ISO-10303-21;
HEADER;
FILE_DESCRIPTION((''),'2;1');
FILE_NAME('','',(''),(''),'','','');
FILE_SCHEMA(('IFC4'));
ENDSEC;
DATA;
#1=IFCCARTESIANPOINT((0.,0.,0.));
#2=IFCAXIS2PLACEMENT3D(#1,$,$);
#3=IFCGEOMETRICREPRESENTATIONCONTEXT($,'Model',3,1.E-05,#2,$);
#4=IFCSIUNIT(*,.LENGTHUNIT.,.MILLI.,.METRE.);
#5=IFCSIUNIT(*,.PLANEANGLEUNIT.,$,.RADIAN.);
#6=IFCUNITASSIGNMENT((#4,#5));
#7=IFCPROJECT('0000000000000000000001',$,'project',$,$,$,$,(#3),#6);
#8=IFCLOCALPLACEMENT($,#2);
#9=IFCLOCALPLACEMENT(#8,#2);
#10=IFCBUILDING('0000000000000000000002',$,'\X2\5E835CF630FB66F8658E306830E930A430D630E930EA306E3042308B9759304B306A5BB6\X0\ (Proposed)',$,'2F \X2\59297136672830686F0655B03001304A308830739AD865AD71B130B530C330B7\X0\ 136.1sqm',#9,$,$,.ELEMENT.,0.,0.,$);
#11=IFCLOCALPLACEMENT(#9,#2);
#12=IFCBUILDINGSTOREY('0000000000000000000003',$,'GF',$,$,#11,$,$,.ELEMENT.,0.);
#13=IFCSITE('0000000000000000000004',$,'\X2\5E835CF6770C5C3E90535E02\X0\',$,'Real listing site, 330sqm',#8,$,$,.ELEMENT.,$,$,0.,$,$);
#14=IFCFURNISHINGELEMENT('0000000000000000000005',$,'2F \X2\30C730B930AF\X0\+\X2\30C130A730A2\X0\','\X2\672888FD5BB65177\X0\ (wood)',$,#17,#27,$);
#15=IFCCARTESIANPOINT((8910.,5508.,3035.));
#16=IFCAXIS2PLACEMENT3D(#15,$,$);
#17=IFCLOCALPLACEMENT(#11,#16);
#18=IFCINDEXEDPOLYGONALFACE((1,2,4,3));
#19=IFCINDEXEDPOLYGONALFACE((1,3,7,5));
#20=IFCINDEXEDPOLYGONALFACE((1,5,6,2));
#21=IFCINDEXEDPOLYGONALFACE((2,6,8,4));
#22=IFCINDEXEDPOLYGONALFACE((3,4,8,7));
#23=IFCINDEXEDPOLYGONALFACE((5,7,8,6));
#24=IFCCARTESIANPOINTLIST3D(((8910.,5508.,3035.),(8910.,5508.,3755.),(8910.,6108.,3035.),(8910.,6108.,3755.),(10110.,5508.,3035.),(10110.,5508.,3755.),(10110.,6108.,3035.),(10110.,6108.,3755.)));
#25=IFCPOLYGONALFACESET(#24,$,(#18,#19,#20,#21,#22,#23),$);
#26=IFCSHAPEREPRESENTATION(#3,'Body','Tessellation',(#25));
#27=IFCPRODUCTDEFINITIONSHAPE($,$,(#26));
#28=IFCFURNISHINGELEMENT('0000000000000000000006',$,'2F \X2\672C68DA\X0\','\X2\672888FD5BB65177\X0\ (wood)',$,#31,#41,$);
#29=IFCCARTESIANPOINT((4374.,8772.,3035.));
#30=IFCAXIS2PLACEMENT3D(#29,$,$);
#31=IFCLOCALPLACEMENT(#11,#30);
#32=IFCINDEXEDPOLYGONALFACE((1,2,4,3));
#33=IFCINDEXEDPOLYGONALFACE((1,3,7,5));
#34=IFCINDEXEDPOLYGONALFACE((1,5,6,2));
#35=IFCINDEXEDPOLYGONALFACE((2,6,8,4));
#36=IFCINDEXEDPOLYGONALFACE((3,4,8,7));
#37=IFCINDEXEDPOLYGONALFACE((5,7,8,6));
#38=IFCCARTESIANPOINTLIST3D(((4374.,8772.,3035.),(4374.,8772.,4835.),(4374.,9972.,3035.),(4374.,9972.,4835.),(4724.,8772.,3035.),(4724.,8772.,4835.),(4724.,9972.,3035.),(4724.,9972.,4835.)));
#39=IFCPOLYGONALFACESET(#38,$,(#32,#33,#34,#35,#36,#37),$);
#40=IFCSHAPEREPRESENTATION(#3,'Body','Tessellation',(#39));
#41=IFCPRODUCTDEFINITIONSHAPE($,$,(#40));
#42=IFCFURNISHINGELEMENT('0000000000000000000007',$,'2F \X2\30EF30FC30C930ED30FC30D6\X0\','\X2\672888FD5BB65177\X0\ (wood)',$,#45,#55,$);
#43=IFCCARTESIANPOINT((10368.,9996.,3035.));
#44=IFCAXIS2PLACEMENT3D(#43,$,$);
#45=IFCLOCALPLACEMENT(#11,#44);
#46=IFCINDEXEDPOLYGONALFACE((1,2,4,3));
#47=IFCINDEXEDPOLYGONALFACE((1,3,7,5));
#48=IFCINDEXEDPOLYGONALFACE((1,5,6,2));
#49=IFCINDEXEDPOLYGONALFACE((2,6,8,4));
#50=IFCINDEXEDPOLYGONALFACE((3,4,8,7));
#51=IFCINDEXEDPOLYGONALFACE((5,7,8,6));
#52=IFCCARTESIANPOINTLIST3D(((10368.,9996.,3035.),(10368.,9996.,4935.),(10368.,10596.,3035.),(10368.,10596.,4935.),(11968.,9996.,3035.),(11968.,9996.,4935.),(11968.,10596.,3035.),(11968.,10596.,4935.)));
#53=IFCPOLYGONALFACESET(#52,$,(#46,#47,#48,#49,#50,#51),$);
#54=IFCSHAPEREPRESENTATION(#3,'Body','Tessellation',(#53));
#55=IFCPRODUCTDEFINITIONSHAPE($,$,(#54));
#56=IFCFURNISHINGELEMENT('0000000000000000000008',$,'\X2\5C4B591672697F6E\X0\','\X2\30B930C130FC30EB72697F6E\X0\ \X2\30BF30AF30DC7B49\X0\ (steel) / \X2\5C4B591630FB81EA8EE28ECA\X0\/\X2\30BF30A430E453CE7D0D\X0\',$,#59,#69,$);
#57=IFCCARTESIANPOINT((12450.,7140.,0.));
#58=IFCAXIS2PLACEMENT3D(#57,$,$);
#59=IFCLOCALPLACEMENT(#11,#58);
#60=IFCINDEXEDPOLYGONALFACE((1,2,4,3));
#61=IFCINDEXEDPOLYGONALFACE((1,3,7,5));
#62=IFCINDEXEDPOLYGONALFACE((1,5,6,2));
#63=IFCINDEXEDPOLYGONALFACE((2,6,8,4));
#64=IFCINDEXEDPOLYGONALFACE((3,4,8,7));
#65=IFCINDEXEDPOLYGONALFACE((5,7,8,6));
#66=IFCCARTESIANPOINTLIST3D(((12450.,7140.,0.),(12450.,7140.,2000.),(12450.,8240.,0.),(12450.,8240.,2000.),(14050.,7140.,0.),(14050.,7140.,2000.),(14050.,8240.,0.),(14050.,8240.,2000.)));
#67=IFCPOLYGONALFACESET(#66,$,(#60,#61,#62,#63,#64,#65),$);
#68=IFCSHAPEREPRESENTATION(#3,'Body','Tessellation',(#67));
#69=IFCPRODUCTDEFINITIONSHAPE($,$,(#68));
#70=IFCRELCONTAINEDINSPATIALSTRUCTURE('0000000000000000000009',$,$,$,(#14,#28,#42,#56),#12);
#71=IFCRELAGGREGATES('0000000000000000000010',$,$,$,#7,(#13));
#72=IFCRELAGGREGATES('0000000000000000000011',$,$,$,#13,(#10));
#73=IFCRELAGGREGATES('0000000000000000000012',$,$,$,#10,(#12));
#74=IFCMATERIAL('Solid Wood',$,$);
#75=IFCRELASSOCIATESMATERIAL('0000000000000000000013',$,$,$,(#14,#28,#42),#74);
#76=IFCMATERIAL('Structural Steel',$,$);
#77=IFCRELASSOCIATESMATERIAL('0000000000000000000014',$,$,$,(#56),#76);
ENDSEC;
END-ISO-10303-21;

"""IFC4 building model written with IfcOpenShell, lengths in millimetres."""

from ifc_helpers import new_model, si_unit, frame, frame_2d, origin, place, context, project, spatial, rectangle, extrude, material, element, save


model = new_model("IFC4")

# Units and contexts
model_context = context("Model", 3, precision=1e-05, world=origin())
ifc_project = project(units=[si_unit("LENGTHUNIT", "METRE", prefix="MILLI"), si_unit("PLANEANGLEUNIT", "RADIAN")], contexts=[model_context])

# Site, building, storey
site_placement = place(None, origin())
site = spatial("IfcSite", under=ifc_project, at=site_placement, Name="広島県尾道市", ObjectType="Real listing site, 330sqm", CompositionType="ELEMENT", RefElevation=0.0)
building_placement = place(site_placement, origin())
building = spatial("IfcBuilding", under=site, at=building_placement, Name="広島・書斎とライブラリのある静かな家 (Proposed)", ObjectType="2F 天然木と漆喰、および高断熱サッシ 136.1sqm", CompositionType="ELEMENT", ElevationOfRefHeight=0.0, ElevationOfTerrain=0.0)
storey_placement = place(building_placement, origin())
storey = spatial("IfcBuildingStorey", under=building, at=storey_placement, Name="GF", CompositionType="ELEMENT", Elevation=0.0)

# Shared definitions
ifc_material_1 = material(Name="Solid Wood")

# Shared definitions
ifc_material_2 = material(Name="Structural Steel")

# Furnishing elements
furnishing_1_placement = place(storey_placement, frame((8910.0, 5508.0, 3035.0)))
element("IfcFurnishingElement", 1, at=furnishing_1_placement, inside=storey, material=ifc_material_1, Name="2F デスク+チェア", Description="木製家具 (wood)", context=model_context, shape_type="SweptSolid", body=[
    extrude(rectangle(XDim=1200.0, YDim=600.0, at=frame_2d((600.0, 300.0))), frame((8910.0, 5508.0, 3035.0)), (0.0, 0.0, 1.0), 720.0),
])
furnishing_2_placement = place(storey_placement, frame((4374.0, 8772.0, 3035.0)))
element("IfcFurnishingElement", 2, at=furnishing_2_placement, inside=storey, material=ifc_material_1, Name="2F 本棚", Description="木製家具 (wood)", context=model_context, shape_type="SweptSolid", body=[
    extrude(rectangle(XDim=350.0, YDim=1200.0, at=frame_2d((175.0, 600.0))), frame((4374.0, 8772.0, 3035.0)), (0.0, 0.0, 1.0), 1800.0),
])
furnishing_3_placement = place(storey_placement, frame((10368.0, 9996.0, 3035.0)))
element("IfcFurnishingElement", 3, at=furnishing_3_placement, inside=storey, material=ifc_material_1, Name="2F ワードローブ", Description="木製家具 (wood)", context=model_context, shape_type="SweptSolid", body=[
    extrude(rectangle(XDim=1600.0, YDim=600.0, at=frame_2d((800.0, 300.0))), frame((10368.0, 9996.0, 3035.0)), (0.0, 0.0, 1.0), 1900.0),
])
furnishing_4_placement = place(storey_placement, frame((12450.0, 7140.0, 0.0)))
element("IfcFurnishingElement", 4, at=furnishing_4_placement, inside=storey, material=ifc_material_2, Name="屋外物置", Description="スチール物置 タクボ等 (steel) / 屋外・自転車/タイヤ収納", context=model_context, shape_type="SweptSolid", body=[
    extrude(rectangle(XDim=1600.0, YDim=1100.0, at=frame_2d((800.0, 550.0))), frame((12450.0, 7140.0, 0.0)), (0.0, 0.0, 1.0), 2000.0),
])

save(model, "model.ifc")
